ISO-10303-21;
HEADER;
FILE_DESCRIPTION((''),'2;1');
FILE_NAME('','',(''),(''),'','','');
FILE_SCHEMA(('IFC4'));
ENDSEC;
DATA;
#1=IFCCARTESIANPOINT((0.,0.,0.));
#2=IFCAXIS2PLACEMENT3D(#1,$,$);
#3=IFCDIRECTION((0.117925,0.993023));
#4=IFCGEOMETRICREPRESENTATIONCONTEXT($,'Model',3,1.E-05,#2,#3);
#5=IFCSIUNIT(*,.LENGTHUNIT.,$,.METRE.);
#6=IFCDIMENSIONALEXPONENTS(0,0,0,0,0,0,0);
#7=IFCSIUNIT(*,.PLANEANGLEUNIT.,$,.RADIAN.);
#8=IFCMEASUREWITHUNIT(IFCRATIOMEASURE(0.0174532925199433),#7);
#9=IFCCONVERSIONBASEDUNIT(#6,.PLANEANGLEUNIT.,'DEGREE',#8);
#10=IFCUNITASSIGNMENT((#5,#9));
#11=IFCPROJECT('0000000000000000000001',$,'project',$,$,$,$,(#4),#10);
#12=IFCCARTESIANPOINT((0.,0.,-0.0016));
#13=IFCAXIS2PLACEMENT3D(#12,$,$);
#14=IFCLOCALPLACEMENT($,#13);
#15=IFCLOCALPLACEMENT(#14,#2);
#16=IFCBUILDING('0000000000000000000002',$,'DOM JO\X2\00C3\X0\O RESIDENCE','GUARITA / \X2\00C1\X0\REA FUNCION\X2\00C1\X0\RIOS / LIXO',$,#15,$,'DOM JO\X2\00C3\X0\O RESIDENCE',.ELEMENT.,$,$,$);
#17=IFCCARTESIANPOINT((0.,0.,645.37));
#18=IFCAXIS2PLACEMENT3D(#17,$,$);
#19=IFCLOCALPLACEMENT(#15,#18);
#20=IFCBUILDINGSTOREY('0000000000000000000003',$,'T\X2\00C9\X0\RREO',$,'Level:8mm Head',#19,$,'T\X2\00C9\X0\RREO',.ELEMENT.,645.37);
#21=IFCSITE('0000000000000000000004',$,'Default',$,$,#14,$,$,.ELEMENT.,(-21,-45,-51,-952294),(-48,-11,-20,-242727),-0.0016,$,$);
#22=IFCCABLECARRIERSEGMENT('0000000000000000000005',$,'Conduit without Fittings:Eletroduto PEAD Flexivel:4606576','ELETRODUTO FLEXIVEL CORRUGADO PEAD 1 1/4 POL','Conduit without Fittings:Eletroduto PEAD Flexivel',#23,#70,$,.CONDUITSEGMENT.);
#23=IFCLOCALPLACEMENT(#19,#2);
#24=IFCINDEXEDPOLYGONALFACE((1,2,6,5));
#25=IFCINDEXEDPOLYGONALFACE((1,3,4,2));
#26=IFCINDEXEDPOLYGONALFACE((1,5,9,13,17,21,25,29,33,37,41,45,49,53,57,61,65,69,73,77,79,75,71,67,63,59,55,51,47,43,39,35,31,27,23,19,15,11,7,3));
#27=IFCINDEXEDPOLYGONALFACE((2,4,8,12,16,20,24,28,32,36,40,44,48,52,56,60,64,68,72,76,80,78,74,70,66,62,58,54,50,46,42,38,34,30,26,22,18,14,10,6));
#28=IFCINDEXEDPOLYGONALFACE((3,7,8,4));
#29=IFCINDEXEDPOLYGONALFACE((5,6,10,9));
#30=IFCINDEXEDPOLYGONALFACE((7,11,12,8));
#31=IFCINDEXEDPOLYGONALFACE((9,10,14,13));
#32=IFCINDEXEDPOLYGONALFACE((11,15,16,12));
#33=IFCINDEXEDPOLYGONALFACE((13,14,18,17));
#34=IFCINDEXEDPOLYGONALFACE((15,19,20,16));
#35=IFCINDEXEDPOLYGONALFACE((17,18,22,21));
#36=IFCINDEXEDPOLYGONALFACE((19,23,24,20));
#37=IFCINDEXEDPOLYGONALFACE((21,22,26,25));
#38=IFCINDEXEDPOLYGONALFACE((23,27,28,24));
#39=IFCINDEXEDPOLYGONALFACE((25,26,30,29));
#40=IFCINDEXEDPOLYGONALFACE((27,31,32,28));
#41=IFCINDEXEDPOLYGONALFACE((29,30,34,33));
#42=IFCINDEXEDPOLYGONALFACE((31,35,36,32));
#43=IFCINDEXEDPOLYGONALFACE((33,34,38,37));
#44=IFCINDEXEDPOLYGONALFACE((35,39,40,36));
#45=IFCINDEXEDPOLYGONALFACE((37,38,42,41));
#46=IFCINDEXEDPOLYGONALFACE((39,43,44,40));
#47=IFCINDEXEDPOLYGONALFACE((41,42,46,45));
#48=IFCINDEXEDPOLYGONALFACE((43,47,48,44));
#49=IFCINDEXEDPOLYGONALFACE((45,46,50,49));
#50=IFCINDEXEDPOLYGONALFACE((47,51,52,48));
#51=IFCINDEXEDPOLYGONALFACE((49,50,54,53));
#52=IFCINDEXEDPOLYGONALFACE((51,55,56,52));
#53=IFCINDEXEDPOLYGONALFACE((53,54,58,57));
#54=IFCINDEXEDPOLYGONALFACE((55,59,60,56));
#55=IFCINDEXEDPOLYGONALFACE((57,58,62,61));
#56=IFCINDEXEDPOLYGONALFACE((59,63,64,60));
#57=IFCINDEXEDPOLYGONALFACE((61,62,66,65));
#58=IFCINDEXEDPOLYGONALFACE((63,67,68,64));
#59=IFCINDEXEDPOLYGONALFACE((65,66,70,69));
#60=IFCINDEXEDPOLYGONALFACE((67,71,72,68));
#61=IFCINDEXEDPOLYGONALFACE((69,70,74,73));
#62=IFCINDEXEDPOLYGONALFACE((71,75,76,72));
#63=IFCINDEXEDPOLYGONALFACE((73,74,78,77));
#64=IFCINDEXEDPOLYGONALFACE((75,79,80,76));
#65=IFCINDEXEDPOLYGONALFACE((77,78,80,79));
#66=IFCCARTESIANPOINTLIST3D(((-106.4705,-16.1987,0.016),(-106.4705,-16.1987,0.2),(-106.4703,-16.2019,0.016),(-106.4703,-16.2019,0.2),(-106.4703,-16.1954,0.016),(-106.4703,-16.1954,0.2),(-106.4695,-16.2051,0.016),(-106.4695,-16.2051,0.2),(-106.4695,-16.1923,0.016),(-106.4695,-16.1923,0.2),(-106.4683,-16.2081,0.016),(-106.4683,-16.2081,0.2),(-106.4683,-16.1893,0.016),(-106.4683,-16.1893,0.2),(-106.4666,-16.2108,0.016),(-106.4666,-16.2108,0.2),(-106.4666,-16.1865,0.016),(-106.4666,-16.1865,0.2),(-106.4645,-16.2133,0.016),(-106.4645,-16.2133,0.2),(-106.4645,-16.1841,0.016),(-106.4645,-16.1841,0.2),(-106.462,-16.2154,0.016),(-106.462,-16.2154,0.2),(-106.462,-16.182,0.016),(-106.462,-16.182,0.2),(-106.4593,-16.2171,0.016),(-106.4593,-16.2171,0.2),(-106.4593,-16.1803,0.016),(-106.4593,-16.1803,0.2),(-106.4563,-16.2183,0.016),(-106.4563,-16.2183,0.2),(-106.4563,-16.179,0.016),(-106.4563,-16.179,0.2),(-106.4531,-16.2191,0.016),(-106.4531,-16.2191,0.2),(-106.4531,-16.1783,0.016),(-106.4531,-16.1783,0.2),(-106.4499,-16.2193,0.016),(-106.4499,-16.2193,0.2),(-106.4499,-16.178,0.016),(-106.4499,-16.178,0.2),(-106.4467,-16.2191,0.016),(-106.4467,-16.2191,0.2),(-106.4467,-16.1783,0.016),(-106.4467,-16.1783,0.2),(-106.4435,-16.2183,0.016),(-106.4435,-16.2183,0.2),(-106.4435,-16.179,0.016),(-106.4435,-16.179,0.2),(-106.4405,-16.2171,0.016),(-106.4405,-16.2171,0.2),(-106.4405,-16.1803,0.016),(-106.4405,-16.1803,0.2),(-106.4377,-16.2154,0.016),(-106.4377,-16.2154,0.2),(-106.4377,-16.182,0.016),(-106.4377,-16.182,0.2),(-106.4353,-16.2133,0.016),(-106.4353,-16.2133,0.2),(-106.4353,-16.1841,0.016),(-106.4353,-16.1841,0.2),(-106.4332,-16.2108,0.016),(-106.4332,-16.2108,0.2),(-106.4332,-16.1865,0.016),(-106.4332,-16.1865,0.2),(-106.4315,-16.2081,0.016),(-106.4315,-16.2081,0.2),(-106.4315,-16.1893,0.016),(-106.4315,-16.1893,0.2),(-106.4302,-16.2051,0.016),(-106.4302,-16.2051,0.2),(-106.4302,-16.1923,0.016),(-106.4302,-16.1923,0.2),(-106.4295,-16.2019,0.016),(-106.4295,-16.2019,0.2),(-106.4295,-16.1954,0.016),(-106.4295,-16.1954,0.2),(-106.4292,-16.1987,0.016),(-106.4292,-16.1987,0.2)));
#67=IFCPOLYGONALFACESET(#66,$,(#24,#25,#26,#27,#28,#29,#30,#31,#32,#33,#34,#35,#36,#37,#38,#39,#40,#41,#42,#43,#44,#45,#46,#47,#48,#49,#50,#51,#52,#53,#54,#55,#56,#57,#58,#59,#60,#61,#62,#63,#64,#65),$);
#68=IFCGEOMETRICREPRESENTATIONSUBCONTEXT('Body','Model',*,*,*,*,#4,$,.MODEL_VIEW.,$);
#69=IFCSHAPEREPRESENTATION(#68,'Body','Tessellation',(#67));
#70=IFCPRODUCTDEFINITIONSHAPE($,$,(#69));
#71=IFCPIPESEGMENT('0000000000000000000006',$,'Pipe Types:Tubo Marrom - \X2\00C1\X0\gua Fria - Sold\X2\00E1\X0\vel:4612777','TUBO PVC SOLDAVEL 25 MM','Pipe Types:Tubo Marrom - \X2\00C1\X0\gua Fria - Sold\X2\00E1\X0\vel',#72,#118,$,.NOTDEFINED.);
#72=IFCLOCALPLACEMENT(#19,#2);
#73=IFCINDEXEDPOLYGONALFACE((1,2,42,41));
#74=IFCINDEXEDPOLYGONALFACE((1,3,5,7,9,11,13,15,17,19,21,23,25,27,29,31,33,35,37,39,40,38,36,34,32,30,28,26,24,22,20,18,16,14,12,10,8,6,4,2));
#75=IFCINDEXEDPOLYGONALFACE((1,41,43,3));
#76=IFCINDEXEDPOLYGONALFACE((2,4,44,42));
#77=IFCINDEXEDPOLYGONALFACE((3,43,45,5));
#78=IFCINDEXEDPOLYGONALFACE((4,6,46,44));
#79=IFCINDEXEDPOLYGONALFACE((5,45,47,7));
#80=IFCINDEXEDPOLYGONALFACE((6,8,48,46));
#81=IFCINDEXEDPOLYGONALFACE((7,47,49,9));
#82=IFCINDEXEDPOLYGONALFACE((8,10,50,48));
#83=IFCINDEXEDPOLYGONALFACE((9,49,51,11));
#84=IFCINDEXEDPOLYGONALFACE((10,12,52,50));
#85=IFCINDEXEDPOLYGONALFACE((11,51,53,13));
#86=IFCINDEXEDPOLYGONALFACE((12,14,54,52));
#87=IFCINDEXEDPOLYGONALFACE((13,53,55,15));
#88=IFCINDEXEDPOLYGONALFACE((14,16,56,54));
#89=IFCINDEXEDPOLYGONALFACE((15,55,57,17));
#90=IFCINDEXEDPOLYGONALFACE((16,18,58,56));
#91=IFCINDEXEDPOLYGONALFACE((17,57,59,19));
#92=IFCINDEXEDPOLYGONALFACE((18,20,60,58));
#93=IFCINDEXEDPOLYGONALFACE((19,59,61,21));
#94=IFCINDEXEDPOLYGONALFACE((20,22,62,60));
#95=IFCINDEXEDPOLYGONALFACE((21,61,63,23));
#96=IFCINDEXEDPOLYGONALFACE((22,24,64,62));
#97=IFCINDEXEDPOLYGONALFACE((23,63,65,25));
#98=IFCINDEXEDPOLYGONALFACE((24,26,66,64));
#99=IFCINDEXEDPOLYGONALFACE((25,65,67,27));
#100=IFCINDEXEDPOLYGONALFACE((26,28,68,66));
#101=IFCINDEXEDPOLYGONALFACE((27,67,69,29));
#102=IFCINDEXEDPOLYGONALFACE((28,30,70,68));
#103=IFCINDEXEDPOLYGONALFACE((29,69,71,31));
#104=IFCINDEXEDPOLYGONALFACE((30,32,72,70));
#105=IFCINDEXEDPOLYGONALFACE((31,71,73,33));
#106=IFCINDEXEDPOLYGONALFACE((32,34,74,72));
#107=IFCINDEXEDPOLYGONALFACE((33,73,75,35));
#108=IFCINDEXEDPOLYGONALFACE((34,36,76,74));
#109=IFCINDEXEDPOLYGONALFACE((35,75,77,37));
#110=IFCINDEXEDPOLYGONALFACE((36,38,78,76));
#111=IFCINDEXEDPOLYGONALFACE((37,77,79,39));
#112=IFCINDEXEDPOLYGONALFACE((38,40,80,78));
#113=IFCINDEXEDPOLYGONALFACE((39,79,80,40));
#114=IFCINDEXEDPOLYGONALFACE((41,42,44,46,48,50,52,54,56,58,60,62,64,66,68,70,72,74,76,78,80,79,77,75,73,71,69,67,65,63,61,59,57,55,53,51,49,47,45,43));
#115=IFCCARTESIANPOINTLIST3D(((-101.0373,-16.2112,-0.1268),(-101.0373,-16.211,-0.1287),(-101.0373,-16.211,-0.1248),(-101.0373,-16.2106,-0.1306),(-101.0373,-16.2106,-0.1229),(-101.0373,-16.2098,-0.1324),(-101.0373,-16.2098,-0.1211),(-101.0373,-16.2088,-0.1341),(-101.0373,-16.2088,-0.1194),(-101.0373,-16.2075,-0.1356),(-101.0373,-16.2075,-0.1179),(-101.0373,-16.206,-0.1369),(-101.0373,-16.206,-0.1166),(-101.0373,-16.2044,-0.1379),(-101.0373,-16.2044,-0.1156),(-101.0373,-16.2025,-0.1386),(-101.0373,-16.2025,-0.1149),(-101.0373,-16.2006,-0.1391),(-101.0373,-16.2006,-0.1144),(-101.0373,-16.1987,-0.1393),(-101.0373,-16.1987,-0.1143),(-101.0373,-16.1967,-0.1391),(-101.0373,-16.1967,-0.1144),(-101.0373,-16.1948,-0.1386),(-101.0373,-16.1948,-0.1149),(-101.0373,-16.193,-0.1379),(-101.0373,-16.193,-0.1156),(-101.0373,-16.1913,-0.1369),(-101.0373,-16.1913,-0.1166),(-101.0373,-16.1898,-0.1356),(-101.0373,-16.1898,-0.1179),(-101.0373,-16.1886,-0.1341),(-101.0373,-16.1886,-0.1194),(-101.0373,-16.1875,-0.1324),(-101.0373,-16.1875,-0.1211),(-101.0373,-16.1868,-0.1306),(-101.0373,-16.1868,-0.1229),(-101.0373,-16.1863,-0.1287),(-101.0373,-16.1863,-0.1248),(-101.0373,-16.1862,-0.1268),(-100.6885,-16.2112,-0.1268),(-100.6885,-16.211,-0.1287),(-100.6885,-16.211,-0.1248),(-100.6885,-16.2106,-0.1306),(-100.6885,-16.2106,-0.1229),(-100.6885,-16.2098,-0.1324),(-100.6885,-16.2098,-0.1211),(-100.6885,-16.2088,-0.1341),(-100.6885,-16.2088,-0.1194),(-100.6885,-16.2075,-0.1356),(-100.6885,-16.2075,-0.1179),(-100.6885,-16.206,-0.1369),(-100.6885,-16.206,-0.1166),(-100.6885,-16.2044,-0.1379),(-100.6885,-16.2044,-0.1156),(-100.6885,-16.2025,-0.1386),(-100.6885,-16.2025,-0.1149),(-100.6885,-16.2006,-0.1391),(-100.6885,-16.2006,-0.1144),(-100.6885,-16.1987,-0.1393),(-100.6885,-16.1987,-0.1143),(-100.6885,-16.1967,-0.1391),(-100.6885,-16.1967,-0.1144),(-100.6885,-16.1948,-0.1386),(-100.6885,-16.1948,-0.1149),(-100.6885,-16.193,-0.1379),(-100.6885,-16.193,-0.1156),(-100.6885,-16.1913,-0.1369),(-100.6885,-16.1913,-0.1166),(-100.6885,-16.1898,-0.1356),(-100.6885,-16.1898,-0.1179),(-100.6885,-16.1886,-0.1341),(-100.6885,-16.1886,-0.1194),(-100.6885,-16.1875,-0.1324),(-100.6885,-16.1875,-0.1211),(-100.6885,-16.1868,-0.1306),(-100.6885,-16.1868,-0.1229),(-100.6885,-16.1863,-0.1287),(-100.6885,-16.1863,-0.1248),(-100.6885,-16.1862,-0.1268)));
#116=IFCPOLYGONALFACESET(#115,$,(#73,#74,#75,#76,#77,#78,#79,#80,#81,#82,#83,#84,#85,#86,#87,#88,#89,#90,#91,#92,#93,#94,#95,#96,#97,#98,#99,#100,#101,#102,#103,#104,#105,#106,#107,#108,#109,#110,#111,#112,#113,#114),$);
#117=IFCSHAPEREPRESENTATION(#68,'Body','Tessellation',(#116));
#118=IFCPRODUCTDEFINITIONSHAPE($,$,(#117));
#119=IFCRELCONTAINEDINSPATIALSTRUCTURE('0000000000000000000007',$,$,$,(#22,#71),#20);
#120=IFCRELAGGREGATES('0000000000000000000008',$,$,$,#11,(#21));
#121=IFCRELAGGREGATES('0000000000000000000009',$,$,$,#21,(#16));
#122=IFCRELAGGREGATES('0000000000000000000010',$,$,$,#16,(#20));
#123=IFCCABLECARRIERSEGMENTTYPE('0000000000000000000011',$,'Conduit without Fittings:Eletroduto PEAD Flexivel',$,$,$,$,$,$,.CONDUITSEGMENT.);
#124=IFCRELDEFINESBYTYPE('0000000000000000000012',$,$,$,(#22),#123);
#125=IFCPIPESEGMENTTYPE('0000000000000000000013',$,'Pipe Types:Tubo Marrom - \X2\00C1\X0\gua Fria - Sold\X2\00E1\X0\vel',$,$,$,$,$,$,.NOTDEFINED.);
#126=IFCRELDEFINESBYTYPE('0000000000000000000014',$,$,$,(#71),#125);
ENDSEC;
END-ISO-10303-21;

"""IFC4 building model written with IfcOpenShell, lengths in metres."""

from ifc_helpers import new_model, entity, si_unit, converted_unit, direction, frame, origin, place, context, subcontext, project, spatial, indexed_curve, outline, extrude, type_object, element, save


model = new_model("IFC4")

# Units and contexts
model_context = context("Model", 3, precision=1e-05, world=origin(), true_north=direction((0.117925, 0.993023)))
body_context = subcontext(model_context, "Body", "Model", "MODEL_VIEW")
ifc_project = project(units=[si_unit("LENGTHUNIT", "METRE"), converted_unit("PLANEANGLEUNIT", "DEGREE", entity("IfcRatioMeasure", 0.0174532925199433), si_unit("PLANEANGLEUNIT", "RADIAN"), dimensions=[0, 0, 0, 0, 0, 0, 0])], contexts=[model_context])

# Site, building, storey
site_placement = place(None, frame((0.0, 0.0, -0.0016)))
site = spatial("IfcSite", under=ifc_project, at=site_placement, Name="Default", CompositionType="ELEMENT", RefLatitude=(-21, -45, -51, -952294), RefLongitude=(-48, -11, -20, -242727), RefElevation=-0.0016)
building_placement = place(site_placement, origin())
building = spatial("IfcBuilding", under=site, at=building_placement, Name="DOM JOÃO RESIDENCE", Description="GUARITA / ÁREA FUNCIONÁRIOS / LIXO", LongName="DOM JOÃO RESIDENCE", CompositionType="ELEMENT")
storey_placement = place(building_placement, frame((0.0, 0.0, 645.37)))
storey = spatial("IfcBuildingStorey", under=building, at=storey_placement, Name="TÉRREO", ObjectType="Level:8mm Head", LongName="TÉRREO", CompositionType="ELEMENT", Elevation=645.37)

# Cable carrier segment
cable_carrier_segment_type = type_object("IfcCableCarrierSegmentType", Name="Conduit without Fittings:Eletroduto PEAD Flexivel", PredefinedType="CONDUITSEGMENT")
cable_carrier_segment_placement = place(storey_placement, frame((-106.4721, -16.2209, 0.016)))
element("IfcCableCarrierSegment", 1, at=cable_carrier_segment_placement, inside=storey, type_object=cable_carrier_segment_type, Name="Conduit without Fittings:Eletroduto PEAD Flexivel:4606576", Description="ELETRODUTO FLEXIVEL CORRUGADO PEAD 1 1/4 POL", ObjectType="Conduit without Fittings:Eletroduto PEAD Flexivel", PredefinedType="CONDUITSEGMENT", context=body_context, shape_type="SweptSolid", body=[
    extrude(outline(indexed_curve([(0.0206, 0.0), (0.0204, 0.0032), (0.0196, 0.0064), (0.0184, 0.0094), (0.0167, 0.0121), (0.0146, 0.0146), (0.0121, 0.0167), (0.0094, 0.0184), (0.0064, 0.0196), (0.0032, 0.0204), (0.0, 0.0206), (-0.0032, 0.0204), (-0.0064, 0.0196), (-0.0094, 0.0184), (-0.0121, 0.0167), (-0.0146, 0.0146), (-0.0167, 0.0121), (-0.0184, 0.0094), (-0.0196, 0.0064), (-0.0204, 0.0032), (-0.0206, 0.0), (-0.0204, -0.0032), (-0.0196, -0.0064), (-0.0184, -0.0094), (-0.0167, -0.0121), (-0.0146, -0.0146), (-0.0121, -0.0167), (-0.0094, -0.0184), (-0.0064, -0.0196), (-0.0032, -0.0204), (0.0, -0.0206), (0.0032, -0.0204), (0.0064, -0.0196), (0.0094, -0.0184), (0.0121, -0.0167), (0.0146, -0.0146), (0.0167, -0.0121), (0.0184, -0.0094), (0.0196, -0.0064), (0.0204, -0.0032), (0.0206, 0.0)], self_intersect=False)), frame((0.0222, 0.0222, 0.0), z_axis=(0.0, 0.0, 1.0), x_axis=(-1.0, 0.0, 0.0)), (0.0, 0.0, 1.0), 0.184),
])

# Pipe segment
pipe_segment_type_1 = type_object("IfcPipeSegmentType", Name="Pipe Types:Tubo Marrom - Água Fria - Soldável", PredefinedType="NOTDEFINED")
pipe_segment_1_placement = place(storey_placement, frame((-101.0373, -16.2128, -0.1409)))
element("IfcPipeSegment", 2, at=pipe_segment_1_placement, inside=storey, type_object=pipe_segment_type_1, Name="Pipe Types:Tubo Marrom - Água Fria - Soldável:4612777", Description="TUBO PVC SOLDAVEL 25 MM", ObjectType="Pipe Types:Tubo Marrom - Água Fria - Soldável", PredefinedType="NOTDEFINED", context=body_context, shape_type="SweptSolid", body=[
    extrude(outline(indexed_curve([(0.0125, 0.0), (0.0123, 0.002), (0.0119, 0.0039), (0.0111, 0.0057), (0.0101, 0.0073), (0.0088, 0.0088), (0.0073, 0.0101), (0.0057, 0.0111), (0.0039, 0.0119), (0.002, 0.0123), (0.0, 0.0125), (-0.002, 0.0123), (-0.0039, 0.0119), (-0.0057, 0.0111), (-0.0073, 0.0101), (-0.0088, 0.0088), (-0.0101, 0.0073), (-0.0111, 0.0057), (-0.0119, 0.0039), (-0.0123, 0.002), (-0.0125, 0.0), (-0.0123, -0.002), (-0.0119, -0.0039), (-0.0111, -0.0057), (-0.0101, -0.0073), (-0.0088, -0.0088), (-0.0073, -0.0101), (-0.0057, -0.0111), (-0.0039, -0.0119), (-0.002, -0.0123), (0.0, -0.0125), (0.002, -0.0123), (0.0039, -0.0119), (0.0057, -0.0111), (0.0073, -0.0101), (0.0088, -0.0088), (0.0101, -0.0073), (0.0111, -0.0057), (0.0119, -0.0039), (0.0123, -0.002), (0.0125, 0.0)], self_intersect=False)), frame((0.0, 0.0141, 0.0141), z_axis=(1.0, 0.0, 0.0), x_axis=(0.0, -1.0, 0.0)), (0.0, 0.0, 1.0), 0.3488),
])

save(model, "model.ifc")
